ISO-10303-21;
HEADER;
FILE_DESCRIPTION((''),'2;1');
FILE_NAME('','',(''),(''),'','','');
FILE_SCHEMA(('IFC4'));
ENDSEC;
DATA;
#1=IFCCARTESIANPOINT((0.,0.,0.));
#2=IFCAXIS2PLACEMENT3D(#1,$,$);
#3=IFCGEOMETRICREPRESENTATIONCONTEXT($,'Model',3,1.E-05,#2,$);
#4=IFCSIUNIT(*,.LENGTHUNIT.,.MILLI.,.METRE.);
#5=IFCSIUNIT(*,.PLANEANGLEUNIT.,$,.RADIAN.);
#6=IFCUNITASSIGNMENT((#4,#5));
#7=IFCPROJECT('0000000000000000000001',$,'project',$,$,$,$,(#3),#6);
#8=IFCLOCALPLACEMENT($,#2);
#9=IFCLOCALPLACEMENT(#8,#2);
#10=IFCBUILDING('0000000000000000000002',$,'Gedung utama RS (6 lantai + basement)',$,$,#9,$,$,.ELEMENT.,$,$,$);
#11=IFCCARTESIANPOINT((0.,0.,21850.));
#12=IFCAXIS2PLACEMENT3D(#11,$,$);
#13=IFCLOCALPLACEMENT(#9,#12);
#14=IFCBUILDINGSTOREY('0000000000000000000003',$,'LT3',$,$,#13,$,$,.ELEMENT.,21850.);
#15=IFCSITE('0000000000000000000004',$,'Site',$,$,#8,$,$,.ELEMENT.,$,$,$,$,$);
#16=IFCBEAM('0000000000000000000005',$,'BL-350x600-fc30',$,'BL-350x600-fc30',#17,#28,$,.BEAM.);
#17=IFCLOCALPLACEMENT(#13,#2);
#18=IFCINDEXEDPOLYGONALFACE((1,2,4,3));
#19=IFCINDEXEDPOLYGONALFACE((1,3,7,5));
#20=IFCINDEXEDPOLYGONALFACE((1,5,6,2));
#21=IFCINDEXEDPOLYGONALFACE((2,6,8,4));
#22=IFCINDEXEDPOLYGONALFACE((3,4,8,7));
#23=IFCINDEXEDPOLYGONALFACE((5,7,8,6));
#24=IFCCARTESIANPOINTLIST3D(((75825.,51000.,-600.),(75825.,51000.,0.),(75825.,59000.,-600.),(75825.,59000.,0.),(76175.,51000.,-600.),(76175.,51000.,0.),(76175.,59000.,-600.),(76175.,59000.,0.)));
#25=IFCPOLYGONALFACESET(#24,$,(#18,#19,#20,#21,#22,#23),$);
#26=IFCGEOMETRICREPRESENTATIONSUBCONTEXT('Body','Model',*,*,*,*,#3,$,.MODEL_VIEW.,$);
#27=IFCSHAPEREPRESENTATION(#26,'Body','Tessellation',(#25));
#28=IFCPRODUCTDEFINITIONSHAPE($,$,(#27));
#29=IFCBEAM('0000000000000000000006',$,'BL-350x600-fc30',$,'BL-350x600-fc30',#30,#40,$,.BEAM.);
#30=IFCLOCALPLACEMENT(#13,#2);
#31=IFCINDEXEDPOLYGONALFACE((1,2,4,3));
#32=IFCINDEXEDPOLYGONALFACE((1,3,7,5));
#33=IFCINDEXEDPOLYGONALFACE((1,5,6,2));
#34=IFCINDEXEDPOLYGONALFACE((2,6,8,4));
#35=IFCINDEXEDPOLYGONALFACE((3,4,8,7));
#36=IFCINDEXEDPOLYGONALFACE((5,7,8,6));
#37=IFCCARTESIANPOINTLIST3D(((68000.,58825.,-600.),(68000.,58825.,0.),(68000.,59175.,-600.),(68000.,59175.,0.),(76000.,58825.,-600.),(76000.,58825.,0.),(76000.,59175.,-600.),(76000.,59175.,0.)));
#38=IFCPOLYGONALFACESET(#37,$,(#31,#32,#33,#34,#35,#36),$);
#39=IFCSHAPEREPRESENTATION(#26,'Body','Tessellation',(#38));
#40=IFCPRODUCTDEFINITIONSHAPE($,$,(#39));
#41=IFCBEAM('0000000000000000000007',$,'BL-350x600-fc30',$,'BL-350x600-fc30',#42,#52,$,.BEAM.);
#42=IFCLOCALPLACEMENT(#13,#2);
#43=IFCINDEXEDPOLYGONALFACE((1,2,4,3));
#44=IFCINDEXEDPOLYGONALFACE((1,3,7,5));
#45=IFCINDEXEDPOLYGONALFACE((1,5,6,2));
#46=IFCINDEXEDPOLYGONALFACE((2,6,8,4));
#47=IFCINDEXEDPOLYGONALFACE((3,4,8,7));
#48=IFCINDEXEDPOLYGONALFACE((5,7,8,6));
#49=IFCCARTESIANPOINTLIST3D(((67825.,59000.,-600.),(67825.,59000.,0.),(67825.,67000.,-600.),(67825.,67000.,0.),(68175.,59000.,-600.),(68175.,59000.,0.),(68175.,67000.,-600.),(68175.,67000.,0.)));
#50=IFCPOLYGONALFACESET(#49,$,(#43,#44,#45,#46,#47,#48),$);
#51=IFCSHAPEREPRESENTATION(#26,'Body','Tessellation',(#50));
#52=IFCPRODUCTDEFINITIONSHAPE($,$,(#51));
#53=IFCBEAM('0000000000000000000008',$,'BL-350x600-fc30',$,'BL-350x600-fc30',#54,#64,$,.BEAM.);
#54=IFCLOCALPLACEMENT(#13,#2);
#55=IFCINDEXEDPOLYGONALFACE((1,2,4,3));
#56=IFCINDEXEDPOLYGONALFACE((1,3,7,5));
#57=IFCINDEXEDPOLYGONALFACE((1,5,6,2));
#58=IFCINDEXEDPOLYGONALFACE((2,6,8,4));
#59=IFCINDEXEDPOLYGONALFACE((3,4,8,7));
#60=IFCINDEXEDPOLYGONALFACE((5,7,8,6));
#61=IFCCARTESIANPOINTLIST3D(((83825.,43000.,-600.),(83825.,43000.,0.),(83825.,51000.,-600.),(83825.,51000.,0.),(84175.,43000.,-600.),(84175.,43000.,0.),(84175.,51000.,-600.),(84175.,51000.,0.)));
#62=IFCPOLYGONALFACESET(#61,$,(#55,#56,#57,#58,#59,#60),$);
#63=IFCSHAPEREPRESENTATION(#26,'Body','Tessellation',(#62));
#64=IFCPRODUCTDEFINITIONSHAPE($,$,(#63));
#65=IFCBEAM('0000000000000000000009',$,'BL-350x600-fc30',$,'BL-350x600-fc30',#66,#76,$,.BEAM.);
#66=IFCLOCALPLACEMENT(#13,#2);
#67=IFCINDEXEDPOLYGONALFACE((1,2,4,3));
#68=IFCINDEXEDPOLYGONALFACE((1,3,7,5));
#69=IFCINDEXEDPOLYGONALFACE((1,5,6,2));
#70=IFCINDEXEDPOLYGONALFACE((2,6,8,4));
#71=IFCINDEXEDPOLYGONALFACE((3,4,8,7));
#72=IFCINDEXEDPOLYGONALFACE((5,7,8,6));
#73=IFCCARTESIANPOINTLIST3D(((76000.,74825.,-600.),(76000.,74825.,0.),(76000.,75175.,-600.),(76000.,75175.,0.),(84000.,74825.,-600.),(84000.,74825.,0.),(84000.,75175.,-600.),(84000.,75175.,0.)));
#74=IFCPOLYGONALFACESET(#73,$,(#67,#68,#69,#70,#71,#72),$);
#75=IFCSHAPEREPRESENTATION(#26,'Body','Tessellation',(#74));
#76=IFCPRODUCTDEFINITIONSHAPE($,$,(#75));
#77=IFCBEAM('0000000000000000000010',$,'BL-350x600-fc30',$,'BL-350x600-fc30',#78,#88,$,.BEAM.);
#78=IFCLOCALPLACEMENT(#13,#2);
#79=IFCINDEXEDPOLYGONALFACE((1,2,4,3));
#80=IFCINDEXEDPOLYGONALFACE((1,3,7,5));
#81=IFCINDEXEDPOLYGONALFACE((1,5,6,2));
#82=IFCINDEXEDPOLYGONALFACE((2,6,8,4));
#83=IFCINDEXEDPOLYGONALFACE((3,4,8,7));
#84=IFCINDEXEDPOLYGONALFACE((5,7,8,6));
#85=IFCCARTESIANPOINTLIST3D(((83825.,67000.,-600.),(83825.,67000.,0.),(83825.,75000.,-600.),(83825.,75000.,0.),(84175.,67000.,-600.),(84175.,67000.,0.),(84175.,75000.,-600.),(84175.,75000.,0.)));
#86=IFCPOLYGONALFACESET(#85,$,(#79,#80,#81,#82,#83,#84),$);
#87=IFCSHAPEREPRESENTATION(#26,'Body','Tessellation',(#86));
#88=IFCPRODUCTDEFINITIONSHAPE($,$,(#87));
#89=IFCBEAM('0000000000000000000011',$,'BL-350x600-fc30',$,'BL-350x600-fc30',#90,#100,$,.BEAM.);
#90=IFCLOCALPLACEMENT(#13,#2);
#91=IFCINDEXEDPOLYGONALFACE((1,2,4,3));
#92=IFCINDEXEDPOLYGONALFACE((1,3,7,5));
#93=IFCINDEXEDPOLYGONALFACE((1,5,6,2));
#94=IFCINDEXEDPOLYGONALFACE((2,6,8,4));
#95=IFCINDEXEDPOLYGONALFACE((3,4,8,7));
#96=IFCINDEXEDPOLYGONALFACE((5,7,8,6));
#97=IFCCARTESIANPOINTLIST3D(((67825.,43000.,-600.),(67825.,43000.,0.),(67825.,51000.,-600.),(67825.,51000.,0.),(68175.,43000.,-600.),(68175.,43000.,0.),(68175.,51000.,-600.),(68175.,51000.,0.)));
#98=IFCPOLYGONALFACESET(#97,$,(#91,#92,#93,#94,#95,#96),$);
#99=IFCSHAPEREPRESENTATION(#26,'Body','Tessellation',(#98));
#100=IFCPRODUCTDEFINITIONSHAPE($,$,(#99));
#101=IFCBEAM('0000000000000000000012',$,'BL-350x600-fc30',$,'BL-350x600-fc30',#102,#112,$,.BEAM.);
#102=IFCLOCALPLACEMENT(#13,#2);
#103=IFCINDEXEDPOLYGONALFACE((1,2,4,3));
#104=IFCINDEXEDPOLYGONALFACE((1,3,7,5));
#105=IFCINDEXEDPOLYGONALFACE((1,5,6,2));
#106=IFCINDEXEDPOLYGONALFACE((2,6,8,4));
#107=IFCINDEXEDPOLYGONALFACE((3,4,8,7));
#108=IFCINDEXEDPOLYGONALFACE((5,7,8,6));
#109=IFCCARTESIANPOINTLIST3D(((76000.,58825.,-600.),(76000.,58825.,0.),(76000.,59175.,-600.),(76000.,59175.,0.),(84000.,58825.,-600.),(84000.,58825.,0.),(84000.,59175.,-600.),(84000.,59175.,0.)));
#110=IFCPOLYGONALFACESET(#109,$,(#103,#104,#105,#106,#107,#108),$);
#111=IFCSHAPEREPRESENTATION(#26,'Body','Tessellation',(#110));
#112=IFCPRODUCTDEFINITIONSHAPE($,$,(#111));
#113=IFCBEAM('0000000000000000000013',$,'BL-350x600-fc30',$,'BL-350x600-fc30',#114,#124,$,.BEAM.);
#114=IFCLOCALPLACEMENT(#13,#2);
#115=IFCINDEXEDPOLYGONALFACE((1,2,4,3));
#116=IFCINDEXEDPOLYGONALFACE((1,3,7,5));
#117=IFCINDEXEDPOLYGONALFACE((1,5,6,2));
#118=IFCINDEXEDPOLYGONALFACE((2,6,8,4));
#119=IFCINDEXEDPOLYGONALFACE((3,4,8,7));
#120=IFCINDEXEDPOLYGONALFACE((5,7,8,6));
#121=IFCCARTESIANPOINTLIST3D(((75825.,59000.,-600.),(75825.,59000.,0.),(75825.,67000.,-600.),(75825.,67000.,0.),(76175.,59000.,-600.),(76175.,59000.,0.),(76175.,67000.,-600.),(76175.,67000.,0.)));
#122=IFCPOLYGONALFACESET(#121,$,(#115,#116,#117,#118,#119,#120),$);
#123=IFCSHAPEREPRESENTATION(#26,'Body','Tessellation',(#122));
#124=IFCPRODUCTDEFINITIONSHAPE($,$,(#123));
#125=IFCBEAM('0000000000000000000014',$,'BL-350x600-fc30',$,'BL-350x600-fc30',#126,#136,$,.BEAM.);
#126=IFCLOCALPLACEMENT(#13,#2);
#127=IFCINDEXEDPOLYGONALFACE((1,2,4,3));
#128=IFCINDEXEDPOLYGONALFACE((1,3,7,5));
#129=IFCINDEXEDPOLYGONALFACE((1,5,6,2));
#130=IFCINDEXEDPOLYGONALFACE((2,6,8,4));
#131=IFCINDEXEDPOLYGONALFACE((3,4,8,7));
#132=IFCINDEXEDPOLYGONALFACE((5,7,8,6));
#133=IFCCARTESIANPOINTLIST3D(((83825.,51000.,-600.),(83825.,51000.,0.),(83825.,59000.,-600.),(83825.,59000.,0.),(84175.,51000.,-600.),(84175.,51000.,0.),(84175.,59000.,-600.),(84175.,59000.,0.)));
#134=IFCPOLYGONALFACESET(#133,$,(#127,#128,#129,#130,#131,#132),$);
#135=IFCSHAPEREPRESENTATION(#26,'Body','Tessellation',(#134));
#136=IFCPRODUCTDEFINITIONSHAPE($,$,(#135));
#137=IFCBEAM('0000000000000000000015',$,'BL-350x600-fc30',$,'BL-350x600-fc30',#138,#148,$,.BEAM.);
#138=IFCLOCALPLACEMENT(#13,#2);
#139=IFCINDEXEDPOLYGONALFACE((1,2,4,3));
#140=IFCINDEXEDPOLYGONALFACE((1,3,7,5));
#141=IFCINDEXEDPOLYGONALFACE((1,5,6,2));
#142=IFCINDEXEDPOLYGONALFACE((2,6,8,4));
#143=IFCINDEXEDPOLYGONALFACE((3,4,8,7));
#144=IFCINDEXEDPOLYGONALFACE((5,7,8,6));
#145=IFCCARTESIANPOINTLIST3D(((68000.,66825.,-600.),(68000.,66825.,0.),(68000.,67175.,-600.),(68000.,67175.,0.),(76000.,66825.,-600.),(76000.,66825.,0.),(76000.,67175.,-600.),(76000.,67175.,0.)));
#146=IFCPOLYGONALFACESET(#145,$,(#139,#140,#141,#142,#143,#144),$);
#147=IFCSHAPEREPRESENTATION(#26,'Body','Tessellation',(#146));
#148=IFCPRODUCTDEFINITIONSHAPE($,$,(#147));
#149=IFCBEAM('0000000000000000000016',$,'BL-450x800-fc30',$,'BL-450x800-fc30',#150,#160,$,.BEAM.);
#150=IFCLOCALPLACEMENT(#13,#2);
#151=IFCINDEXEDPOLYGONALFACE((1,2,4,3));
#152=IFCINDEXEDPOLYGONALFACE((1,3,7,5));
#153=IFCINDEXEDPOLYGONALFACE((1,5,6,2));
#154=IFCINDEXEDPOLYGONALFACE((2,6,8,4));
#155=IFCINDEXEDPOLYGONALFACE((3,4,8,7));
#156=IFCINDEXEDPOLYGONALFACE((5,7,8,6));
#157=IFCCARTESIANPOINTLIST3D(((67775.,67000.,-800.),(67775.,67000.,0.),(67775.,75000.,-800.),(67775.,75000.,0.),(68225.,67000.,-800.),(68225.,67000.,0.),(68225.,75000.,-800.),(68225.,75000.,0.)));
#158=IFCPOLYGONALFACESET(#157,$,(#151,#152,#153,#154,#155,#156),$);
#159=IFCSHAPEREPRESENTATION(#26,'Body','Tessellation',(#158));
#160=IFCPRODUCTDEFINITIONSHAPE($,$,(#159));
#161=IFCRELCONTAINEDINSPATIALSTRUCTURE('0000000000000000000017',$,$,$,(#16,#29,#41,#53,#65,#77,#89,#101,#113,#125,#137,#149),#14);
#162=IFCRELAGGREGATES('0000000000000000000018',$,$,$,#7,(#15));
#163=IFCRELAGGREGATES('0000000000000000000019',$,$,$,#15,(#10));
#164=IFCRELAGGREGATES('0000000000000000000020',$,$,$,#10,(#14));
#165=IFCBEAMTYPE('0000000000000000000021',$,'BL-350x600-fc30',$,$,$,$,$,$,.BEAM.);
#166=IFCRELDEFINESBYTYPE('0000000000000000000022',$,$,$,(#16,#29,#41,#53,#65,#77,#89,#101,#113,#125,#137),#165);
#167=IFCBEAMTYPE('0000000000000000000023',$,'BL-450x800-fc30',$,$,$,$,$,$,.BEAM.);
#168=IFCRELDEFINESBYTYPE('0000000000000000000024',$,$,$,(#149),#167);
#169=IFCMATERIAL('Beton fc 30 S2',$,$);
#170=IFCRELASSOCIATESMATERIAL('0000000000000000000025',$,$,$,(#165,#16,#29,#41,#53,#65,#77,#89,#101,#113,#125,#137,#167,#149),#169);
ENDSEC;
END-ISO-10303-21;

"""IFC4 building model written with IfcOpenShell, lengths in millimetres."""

from ifc_helpers import new_model, si_unit, frame, origin, origin_2d, place, context, subcontext, project, spatial, rectangle, extrude, material, material_profile, profile_set, profile_usage, type_object, element, save


model = new_model("IFC4")

# Units and contexts
model_context = context("Model", 3, precision=1e-05, world=origin())
body_context = subcontext(model_context, "Body", "Model", "MODEL_VIEW")
ifc_project = project(units=[si_unit("LENGTHUNIT", "METRE", prefix="MILLI"), si_unit("PLANEANGLEUNIT", "RADIAN")], contexts=[model_context])

# Site, building, storey
site_placement = place(None, origin())
site = spatial("IfcSite", under=ifc_project, at=site_placement, Name="Site", CompositionType="ELEMENT")
building_placement = place(site_placement, origin())
building = spatial("IfcBuilding", under=site, at=building_placement, Name="Gedung utama RS (6 lantai + basement)", CompositionType="ELEMENT")
storey_placement = place(building_placement, frame((0.0, 0.0, 21850.0)))
storey = spatial("IfcBuildingStorey", under=building, at=storey_placement, Name="LT3", CompositionType="ELEMENT", Elevation=21850.0)

# Beams
ifc_material = material(Name="Beton fc 30 S2")
ifc_material_profile_1 = material_profile(ifc_material, rectangle(XDim=350.0, YDim=600.0, at=origin_2d()), Name="BL-350x600-fc30")
ifc_profile_set_1 = profile_set([ifc_material_profile_1], Name="BL-350x600-fc30")
ifc_profile_usage_1 = profile_usage(ifc_profile_set_1, cardinal=8)
beam_type_1 = type_object("IfcBeamType", Name="BL-350x600-fc30", PredefinedType="BEAM", material=ifc_profile_set_1)
beam_1_placement = place(storey_placement, frame((76000.0, 51000.0, -300.0)))
element("IfcBeam", 1, at=beam_1_placement, inside=storey, type_object=beam_type_1, material=ifc_profile_usage_1, Name="BL-350x600-fc30", ObjectType="BL-350x600-fc30", PredefinedType="BEAM", context=body_context, shape_type="SweptSolid", body=[
    extrude(rectangle(XDim=350.0, YDim=600.0, at=origin_2d()), frame((0.0, 0.0, 0.0), z_axis=(0.0, 1.0, 0.0), x_axis=(-1.0, 0.0, 0.0)), (0.0, 0.0, 1.0), 8000.0),
])
beam_2_placement = place(storey_placement, frame((68000.0, 59000.0, -300.0)))
element("IfcBeam", 2, at=beam_2_placement, inside=storey, type_object=beam_type_1, material=ifc_profile_usage_1, Name="BL-350x600-fc30", ObjectType="BL-350x600-fc30", PredefinedType="BEAM", context=body_context, shape_type="SweptSolid", body=[
    extrude(rectangle(XDim=350.0, YDim=600.0, at=origin_2d()), frame((0.0, 0.0, 0.0), z_axis=(1.0, 0.0, 0.0), x_axis=(0.0, 1.0, 0.0)), (0.0, 0.0, 1.0), 8000.0),
])
for number, where, name in (
    (3, (68000.0, 59000.0, -300.0), "BL-350x600-fc30"),
    (4, (84000.0, 43000.0, -300.0), "BL-350x600-fc30"),
):
    element("IfcBeam", number, at=place(storey_placement, frame(where)), inside=storey, type_object=beam_type_1, material=ifc_profile_usage_1, Name=name, ObjectType="BL-350x600-fc30", PredefinedType="BEAM", context=body_context, shape_type="SweptSolid", body=[
        extrude(rectangle(XDim=350.0, YDim=600.0, at=origin_2d()), frame((0.0, 0.0, 0.0), z_axis=(0.0, 1.0, 0.0), x_axis=(-1.0, 0.0, 0.0)), (0.0, 0.0, 1.0), 8000.0),
    ])
beam_3_placement = place(storey_placement, frame((76000.0, 75000.0, -300.0)))
element("IfcBeam", 5, at=beam_3_placement, inside=storey, type_object=beam_type_1, material=ifc_profile_usage_1, Name="BL-350x600-fc30", ObjectType="BL-350x600-fc30", PredefinedType="BEAM", context=body_context, shape_type="SweptSolid", body=[
    extrude(rectangle(XDim=350.0, YDim=600.0, at=origin_2d()), frame((0.0, 0.0, 0.0), z_axis=(1.0, 0.0, 0.0), x_axis=(0.0, 1.0, 0.0)), (0.0, 0.0, 1.0), 8000.0),
])
for number, where, name in (
    (6, (84000.0, 67000.0, -300.0), "BL-350x600-fc30"),
    (7, (68000.0, 43000.0, -300.0), "BL-350x600-fc30"),
):
    element("IfcBeam", number, at=place(storey_placement, frame(where)), inside=storey, type_object=beam_type_1, material=ifc_profile_usage_1, Name=name, ObjectType="BL-350x600-fc30", PredefinedType="BEAM", context=body_context, shape_type="SweptSolid", body=[
        extrude(rectangle(XDim=350.0, YDim=600.0, at=origin_2d()), frame((0.0, 0.0, 0.0), z_axis=(0.0, 1.0, 0.0), x_axis=(-1.0, 0.0, 0.0)), (0.0, 0.0, 1.0), 8000.0),
    ])
beam_4_placement = place(storey_placement, frame((76000.0, 59000.0, -300.0)))
element("IfcBeam", 8, at=beam_4_placement, inside=storey, type_object=beam_type_1, material=ifc_profile_usage_1, Name="BL-350x600-fc30", ObjectType="BL-350x600-fc30", PredefinedType="BEAM", context=body_context, shape_type="SweptSolid", body=[
    extrude(rectangle(XDim=350.0, YDim=600.0, at=origin_2d()), frame((0.0, 0.0, 0.0), z_axis=(1.0, 0.0, 0.0), x_axis=(0.0, 1.0, 0.0)), (0.0, 0.0, 1.0), 8000.0),
])
for number, where, name in (
    (9, (76000.0, 59000.0, -300.0), "BL-350x600-fc30"),
    (10, (84000.0, 51000.0, -300.0), "BL-350x600-fc30"),
):
    element("IfcBeam", number, at=place(storey_placement, frame(where)), inside=storey, type_object=beam_type_1, material=ifc_profile_usage_1, Name=name, ObjectType="BL-350x600-fc30", PredefinedType="BEAM", context=body_context, shape_type="SweptSolid", body=[
        extrude(rectangle(XDim=350.0, YDim=600.0, at=origin_2d()), frame((0.0, 0.0, 0.0), z_axis=(0.0, 1.0, 0.0), x_axis=(-1.0, 0.0, 0.0)), (0.0, 0.0, 1.0), 8000.0),
    ])
beam_5_placement = place(storey_placement, frame((68000.0, 67000.0, -300.0)))
element("IfcBeam", 11, at=beam_5_placement, inside=storey, type_object=beam_type_1, material=ifc_profile_usage_1, Name="BL-350x600-fc30", ObjectType="BL-350x600-fc30", PredefinedType="BEAM", context=body_context, shape_type="SweptSolid", body=[
    extrude(rectangle(XDim=350.0, YDim=600.0, at=origin_2d()), frame((0.0, 0.0, 0.0), z_axis=(1.0, 0.0, 0.0), x_axis=(0.0, 1.0, 0.0)), (0.0, 0.0, 1.0), 8000.0),
])
ifc_material_profile_2 = material_profile(ifc_material, rectangle(XDim=450.0, YDim=800.0, at=origin_2d()), Name="BL-450x800-fc30")
ifc_profile_set_2 = profile_set([ifc_material_profile_2], Name="BL-450x800-fc30")
ifc_profile_usage_2 = profile_usage(ifc_profile_set_2, cardinal=8)
beam_type_2 = type_object("IfcBeamType", Name="BL-450x800-fc30", PredefinedType="BEAM", material=ifc_profile_set_2)
beam_6_placement = place(storey_placement, frame((68000.0, 67000.0, -400.0)))
element("IfcBeam", 12, at=beam_6_placement, inside=storey, type_object=beam_type_2, material=ifc_profile_usage_2, Name="BL-450x800-fc30", ObjectType="BL-450x800-fc30", PredefinedType="BEAM", context=body_context, shape_type="SweptSolid", body=[
    extrude(rectangle(XDim=450.0, YDim=800.0, at=origin_2d()), frame((0.0, 0.0, 0.0), z_axis=(0.0, 1.0, 0.0), x_axis=(-1.0, 0.0, 0.0)), (0.0, 0.0, 1.0), 8000.0),
])

save(model, "model.ifc")
